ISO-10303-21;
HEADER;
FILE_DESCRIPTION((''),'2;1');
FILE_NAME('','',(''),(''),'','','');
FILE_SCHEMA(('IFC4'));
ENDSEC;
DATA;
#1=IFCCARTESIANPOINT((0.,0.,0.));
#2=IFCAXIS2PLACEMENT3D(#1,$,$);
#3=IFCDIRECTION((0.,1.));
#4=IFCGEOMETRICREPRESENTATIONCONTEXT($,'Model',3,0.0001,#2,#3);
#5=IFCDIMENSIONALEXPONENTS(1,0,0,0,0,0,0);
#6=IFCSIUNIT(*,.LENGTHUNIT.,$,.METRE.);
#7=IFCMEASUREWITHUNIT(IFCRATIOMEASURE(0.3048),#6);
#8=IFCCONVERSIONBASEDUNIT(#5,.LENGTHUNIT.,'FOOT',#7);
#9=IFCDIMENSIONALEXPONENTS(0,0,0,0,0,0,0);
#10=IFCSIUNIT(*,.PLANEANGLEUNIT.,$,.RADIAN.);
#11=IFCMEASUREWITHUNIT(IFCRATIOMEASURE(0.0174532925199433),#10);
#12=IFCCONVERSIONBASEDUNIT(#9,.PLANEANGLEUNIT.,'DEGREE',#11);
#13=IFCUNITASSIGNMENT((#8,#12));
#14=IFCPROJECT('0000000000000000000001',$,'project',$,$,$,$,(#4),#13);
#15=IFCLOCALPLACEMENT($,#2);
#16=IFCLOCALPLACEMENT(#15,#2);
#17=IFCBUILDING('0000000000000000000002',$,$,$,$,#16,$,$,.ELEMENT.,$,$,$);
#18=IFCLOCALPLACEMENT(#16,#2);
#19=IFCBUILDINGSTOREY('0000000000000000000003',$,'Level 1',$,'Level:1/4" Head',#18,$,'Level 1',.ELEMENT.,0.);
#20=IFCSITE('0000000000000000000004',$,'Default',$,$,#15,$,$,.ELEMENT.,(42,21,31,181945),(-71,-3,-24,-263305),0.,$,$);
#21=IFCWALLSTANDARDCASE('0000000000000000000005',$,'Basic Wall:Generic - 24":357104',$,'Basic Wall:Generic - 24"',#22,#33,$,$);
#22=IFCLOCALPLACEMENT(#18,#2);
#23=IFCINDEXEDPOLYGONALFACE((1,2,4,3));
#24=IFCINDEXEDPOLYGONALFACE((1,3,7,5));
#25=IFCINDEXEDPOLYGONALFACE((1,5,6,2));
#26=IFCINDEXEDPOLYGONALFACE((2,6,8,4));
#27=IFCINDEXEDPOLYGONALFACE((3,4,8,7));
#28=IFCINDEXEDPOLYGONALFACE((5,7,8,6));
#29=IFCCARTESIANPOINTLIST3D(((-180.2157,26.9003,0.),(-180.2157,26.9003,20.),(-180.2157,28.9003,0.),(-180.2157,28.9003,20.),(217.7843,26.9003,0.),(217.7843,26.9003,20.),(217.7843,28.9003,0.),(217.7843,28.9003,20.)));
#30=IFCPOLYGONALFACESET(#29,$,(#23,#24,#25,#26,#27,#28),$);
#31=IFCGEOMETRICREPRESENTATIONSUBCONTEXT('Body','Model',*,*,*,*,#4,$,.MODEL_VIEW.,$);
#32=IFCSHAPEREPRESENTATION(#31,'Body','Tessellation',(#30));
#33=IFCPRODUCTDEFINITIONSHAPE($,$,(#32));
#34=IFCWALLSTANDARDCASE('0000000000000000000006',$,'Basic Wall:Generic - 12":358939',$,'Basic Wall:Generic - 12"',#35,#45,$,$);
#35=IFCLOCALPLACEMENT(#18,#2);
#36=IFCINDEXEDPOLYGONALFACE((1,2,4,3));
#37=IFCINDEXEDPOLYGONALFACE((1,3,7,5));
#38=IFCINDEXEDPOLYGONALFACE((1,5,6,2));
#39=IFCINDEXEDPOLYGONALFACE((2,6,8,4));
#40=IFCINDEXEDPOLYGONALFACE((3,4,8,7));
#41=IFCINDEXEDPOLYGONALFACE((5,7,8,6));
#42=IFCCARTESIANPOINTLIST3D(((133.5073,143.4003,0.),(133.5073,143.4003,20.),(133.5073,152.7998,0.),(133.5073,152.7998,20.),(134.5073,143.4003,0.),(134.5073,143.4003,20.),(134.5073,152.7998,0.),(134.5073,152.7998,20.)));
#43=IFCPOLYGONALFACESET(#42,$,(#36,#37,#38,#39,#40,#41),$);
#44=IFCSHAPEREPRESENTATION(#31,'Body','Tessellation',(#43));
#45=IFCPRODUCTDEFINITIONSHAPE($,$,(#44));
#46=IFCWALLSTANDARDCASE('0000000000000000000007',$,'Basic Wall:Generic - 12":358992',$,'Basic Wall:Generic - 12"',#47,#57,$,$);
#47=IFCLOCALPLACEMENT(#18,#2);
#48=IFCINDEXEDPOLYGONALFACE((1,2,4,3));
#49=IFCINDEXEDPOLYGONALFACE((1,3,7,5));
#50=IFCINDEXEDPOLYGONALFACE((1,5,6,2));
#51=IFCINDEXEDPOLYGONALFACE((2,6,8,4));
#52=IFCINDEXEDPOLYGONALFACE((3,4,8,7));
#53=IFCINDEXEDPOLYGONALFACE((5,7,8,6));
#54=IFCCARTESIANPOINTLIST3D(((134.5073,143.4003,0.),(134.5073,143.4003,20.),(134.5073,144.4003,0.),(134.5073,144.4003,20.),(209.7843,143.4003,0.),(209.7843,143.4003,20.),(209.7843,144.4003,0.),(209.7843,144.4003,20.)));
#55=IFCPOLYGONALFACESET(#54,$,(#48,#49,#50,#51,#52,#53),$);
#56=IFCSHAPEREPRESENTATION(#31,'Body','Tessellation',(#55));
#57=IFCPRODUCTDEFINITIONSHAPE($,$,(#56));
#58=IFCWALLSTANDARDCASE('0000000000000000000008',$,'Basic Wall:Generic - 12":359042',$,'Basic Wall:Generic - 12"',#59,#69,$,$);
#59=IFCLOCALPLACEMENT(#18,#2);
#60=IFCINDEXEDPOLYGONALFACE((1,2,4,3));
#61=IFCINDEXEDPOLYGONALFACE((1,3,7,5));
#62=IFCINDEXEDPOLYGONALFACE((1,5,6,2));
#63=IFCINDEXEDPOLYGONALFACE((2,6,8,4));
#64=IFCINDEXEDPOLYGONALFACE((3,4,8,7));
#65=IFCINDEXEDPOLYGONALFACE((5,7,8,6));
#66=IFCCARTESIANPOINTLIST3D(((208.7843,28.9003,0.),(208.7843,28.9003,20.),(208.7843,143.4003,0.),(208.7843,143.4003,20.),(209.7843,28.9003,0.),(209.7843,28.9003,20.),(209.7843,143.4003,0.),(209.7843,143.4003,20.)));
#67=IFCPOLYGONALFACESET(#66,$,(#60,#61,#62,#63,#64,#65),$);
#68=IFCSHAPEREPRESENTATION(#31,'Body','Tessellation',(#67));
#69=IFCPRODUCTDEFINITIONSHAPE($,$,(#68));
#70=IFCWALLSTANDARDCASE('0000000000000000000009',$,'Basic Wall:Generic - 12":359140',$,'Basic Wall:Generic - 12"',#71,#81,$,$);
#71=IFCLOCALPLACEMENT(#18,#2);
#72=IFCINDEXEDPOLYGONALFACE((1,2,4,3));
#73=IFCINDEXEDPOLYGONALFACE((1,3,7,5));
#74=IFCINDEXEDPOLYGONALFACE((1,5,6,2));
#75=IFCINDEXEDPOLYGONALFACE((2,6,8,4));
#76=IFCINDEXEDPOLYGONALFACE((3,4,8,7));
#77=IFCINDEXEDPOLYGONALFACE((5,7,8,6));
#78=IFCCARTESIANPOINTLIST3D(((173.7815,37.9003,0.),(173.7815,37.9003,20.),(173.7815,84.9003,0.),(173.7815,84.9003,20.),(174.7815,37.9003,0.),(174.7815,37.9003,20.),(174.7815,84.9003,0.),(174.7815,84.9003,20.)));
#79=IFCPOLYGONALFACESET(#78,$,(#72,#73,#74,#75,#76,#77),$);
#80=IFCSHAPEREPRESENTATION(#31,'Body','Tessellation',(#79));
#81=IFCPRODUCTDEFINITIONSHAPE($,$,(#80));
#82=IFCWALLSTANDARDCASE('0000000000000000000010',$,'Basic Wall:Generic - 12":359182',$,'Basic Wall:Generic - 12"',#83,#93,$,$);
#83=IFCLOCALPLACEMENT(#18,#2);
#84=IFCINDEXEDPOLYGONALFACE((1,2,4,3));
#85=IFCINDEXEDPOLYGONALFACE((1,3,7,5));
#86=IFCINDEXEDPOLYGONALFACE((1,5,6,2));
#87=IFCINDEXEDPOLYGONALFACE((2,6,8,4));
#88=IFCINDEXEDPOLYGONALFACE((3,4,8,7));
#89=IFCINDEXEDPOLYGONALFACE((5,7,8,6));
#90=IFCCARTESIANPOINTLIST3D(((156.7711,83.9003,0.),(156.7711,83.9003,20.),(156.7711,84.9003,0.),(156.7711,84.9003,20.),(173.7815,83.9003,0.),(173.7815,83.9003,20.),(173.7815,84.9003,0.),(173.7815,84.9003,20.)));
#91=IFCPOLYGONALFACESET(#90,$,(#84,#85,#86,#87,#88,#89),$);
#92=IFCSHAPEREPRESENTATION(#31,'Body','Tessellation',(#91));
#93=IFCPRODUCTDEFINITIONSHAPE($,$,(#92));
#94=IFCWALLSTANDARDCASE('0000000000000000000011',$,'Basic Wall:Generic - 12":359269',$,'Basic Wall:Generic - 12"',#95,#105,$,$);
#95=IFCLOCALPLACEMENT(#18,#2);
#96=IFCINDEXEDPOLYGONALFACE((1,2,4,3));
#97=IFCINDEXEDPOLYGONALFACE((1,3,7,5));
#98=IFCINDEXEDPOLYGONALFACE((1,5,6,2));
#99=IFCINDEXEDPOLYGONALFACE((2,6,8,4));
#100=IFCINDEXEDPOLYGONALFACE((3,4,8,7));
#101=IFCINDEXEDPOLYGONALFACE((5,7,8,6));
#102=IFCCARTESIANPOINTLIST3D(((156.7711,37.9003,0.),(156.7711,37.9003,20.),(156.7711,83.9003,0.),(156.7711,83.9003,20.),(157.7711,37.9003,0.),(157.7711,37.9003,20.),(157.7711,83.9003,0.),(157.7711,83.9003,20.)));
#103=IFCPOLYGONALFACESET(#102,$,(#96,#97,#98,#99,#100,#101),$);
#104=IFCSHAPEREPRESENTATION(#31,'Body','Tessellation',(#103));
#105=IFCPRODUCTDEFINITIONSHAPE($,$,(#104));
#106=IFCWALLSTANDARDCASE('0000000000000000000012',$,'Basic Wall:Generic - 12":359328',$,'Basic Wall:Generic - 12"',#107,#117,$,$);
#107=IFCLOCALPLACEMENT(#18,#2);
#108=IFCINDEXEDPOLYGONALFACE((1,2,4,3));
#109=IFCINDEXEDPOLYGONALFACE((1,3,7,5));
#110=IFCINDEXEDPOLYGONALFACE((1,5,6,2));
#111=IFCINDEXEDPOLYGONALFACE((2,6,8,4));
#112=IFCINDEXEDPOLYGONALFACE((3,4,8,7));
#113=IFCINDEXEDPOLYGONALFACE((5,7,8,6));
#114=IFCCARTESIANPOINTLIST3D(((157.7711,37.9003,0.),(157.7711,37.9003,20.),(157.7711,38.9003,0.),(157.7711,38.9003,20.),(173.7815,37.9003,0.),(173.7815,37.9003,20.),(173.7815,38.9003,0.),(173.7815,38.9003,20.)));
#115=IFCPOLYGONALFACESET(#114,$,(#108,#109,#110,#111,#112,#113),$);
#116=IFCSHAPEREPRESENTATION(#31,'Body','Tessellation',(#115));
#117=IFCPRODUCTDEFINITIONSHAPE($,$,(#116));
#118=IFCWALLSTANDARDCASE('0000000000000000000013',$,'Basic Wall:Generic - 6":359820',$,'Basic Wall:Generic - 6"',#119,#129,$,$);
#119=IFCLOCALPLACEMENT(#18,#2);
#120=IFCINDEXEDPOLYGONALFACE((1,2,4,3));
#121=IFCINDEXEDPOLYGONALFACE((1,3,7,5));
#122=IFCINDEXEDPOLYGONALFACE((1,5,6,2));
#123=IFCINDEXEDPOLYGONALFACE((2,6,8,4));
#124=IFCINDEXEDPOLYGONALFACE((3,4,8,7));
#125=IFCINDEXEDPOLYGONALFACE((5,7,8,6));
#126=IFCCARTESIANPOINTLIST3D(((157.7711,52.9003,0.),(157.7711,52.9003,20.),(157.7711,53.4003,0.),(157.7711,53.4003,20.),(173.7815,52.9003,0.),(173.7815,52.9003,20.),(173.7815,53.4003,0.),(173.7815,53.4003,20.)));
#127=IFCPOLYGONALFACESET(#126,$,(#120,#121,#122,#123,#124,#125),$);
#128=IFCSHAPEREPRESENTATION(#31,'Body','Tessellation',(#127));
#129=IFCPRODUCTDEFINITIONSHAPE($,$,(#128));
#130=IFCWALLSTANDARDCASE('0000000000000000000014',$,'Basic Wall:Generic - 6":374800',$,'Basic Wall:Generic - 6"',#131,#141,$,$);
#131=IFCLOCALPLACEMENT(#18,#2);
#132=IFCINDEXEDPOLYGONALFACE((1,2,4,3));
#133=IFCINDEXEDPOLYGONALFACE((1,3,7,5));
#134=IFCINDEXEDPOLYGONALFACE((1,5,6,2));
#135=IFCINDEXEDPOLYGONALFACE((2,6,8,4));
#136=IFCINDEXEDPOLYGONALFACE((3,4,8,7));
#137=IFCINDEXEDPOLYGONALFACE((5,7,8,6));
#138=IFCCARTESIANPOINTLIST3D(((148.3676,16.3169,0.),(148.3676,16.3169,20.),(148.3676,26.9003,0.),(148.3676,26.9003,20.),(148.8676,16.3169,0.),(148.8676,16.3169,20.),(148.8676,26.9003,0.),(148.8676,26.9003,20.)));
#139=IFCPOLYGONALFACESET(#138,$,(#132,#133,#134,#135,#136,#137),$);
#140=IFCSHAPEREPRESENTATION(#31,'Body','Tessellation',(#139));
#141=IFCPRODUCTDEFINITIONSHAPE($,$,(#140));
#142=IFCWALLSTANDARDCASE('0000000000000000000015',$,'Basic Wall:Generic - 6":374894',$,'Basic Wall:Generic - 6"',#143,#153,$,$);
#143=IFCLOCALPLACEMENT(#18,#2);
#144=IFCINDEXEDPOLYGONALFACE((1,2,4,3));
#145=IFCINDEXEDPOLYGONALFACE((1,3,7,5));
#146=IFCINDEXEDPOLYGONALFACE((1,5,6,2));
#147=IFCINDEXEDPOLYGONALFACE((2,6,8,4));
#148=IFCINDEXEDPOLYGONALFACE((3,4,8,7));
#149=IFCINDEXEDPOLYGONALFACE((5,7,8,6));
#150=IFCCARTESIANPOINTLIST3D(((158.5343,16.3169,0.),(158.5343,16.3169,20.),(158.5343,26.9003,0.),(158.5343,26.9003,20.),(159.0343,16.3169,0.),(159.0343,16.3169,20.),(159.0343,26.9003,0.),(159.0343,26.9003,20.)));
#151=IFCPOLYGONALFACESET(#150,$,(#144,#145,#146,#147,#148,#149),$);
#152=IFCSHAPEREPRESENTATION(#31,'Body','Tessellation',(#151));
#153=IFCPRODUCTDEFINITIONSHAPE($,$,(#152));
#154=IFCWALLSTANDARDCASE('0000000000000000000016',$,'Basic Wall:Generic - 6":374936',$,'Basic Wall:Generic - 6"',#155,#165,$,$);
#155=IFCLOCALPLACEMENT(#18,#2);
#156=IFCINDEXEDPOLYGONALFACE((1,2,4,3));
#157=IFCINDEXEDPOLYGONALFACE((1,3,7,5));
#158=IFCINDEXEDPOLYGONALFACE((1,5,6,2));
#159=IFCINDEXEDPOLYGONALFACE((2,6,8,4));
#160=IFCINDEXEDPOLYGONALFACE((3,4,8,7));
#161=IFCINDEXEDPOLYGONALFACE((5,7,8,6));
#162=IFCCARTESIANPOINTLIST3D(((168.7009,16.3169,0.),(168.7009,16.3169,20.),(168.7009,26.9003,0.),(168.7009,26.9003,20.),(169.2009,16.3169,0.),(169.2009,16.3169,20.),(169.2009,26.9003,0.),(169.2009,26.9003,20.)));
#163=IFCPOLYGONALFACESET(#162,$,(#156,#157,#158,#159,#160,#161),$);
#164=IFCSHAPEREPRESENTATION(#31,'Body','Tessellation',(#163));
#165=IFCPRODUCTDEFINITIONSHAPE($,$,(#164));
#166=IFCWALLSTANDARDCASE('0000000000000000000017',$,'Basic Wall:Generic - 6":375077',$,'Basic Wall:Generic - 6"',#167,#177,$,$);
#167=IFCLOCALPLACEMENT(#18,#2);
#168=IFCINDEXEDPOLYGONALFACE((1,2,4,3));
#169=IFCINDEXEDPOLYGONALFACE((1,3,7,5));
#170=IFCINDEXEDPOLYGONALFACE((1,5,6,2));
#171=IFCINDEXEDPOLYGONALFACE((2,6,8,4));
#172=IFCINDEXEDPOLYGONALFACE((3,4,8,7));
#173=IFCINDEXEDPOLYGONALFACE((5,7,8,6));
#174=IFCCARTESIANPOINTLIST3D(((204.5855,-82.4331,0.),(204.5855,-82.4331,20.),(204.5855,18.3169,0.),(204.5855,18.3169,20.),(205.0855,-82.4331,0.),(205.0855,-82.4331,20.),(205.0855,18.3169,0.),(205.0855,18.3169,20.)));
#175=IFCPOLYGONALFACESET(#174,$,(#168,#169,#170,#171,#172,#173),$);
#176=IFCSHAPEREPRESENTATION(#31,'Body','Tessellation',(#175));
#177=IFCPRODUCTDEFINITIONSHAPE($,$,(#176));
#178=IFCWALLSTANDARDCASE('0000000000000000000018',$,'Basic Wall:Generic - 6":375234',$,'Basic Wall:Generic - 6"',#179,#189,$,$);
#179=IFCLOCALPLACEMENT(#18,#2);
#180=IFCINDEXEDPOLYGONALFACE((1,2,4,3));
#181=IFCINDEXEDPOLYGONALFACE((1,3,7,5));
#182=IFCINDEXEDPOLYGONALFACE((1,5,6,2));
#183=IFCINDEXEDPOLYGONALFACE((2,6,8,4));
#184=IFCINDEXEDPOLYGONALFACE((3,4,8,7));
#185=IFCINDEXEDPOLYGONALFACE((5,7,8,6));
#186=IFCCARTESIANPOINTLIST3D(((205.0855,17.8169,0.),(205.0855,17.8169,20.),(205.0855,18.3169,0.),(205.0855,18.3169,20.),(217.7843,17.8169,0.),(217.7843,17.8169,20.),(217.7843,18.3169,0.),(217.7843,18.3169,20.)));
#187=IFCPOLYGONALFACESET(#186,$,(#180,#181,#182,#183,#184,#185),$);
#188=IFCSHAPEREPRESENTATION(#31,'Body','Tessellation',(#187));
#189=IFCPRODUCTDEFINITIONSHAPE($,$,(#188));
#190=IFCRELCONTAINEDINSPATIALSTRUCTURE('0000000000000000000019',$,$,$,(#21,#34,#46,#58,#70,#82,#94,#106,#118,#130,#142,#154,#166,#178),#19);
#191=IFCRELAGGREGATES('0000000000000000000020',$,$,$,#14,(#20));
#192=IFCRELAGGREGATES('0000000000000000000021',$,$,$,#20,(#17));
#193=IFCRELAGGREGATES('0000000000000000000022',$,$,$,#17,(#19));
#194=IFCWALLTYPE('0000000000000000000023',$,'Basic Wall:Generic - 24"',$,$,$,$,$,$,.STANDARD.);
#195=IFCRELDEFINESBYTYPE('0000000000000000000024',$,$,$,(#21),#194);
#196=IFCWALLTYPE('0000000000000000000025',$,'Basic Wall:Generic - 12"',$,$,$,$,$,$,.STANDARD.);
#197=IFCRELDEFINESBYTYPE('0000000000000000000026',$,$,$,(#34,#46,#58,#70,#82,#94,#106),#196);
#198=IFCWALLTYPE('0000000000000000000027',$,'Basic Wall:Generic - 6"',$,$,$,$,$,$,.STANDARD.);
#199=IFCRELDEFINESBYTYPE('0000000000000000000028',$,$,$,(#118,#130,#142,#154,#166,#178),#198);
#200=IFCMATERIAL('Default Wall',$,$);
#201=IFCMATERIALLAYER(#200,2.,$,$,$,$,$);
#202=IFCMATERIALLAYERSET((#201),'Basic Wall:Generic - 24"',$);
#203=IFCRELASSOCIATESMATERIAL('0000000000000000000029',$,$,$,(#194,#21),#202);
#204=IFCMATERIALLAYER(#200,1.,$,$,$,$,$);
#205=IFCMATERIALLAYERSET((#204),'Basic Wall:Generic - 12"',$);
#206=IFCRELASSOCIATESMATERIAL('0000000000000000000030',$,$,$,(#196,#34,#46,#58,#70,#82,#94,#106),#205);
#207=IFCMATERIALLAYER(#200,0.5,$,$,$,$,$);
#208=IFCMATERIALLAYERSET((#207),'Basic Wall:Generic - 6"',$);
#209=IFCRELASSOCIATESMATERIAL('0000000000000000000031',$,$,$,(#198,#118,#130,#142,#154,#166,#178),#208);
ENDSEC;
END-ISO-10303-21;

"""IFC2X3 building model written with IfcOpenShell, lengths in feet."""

from ifc_helpers import new_model, entity, si_unit, converted_unit, direction, frame, frame_2d, origin, place, context, subcontext, project, spatial, rectangle, extrude, material, layer, layer_set, layer_usage, type_object, element, save


model = new_model("IFC2X3")

# Units and contexts
model_context = context("Model", 3, precision=0.0001, world=origin(), true_north=direction((0.0, 1.0)))
body_context = subcontext(model_context, "Body", "Model", "MODEL_VIEW")
ifc_project = project(units=[converted_unit("LENGTHUNIT", "FOOT", entity("IfcRatioMeasure", 0.3048), si_unit("LENGTHUNIT", "METRE"), dimensions=[1, 0, 0, 0, 0, 0, 0]), converted_unit("PLANEANGLEUNIT", "DEGREE", entity("IfcRatioMeasure", 0.0174532925199433), si_unit("PLANEANGLEUNIT", "RADIAN"), dimensions=[0, 0, 0, 0, 0, 0, 0])], contexts=[model_context])

# Site, building, storey
site_placement = place(None, origin())
site = spatial("IfcSite", under=ifc_project, at=site_placement, Name="Default", CompositionType="ELEMENT", RefLatitude=(42, 21, 31, 181945), RefLongitude=(-71, -3, -24, -263305), RefElevation=0.0)
building_placement = place(site_placement, origin())
building = spatial("IfcBuilding", under=site, at=building_placement, CompositionType="ELEMENT")
storey_placement = place(building_placement, origin())
storey = spatial("IfcBuildingStorey", under=building, at=storey_placement, Name="Level 1", ObjectType="Level:1/4\" Head", LongName="Level 1", CompositionType="ELEMENT", Elevation=0.0)

# Walls
ifc_material = material(Name="Default Wall")
ifc_layer_1 = layer(ifc_material, 2.0)
ifc_layer_set_1 = layer_set([ifc_layer_1], Name="Basic Wall:Generic - 24\"")
ifc_layer_usage_1 = layer_usage(ifc_layer_set_1, "AXIS2", "NEGATIVE", 1.0)
wall_type_1 = type_object("IfcWallType", Name="Basic Wall:Generic - 24\"", PredefinedType="STANDARD", material=ifc_layer_set_1)
wall_1_placement = place(storey_placement, frame((217.7843, 27.9003, 0.0), z_axis=(0.0, 0.0, 1.0), x_axis=(-1.0, 0.0, 0.0)))
element("IfcWallStandardCase", 1, at=wall_1_placement, inside=storey, type_object=wall_type_1, material=ifc_layer_usage_1, Name="Basic Wall:Generic - 24\":357104", ObjectType="Basic Wall:Generic - 24\"", context=body_context, shape_type="SweptSolid", body=[
    extrude(rectangle(XDim=398.0, YDim=2.0, at=frame_2d((199.0, 0.0), x_axis=(-1.0, 0.0))), origin(), (0.0, 0.0, 1.0), 20.0),
])
ifc_layer_2 = layer(ifc_material, 1.0)
ifc_layer_set_2 = layer_set([ifc_layer_2], Name="Basic Wall:Generic - 12\"")
ifc_layer_usage_2 = layer_usage(ifc_layer_set_2, "AXIS2", "NEGATIVE", 0.5)
wall_type_2 = type_object("IfcWallType", Name="Basic Wall:Generic - 12\"", PredefinedType="STANDARD", material=ifc_layer_set_2)
wall_2_placement = place(storey_placement, frame((134.0073, 152.7998, 0.0), z_axis=(0.0, 0.0, 1.0), x_axis=(0.0, -1.0, 0.0)))
element("IfcWallStandardCase", 2, at=wall_2_placement, inside=storey, type_object=wall_type_2, material=ifc_layer_usage_2, Name="Basic Wall:Generic - 12\":358939", ObjectType="Basic Wall:Generic - 12\"", context=body_context, shape_type="SweptSolid", body=[
    extrude(rectangle(XDim=9.3995, YDim=1.0, at=frame_2d((4.6998, 0.0), x_axis=(-1.0, 0.0))), origin(), (0.0, 0.0, 1.0), 20.0),
])
ifc_layer_usage_3 = layer_usage(ifc_layer_set_2, "AXIS2", "NEGATIVE", 0.5)
wall_3_placement = place(storey_placement, frame((134.5073, 143.9003, 0.0)))
element("IfcWallStandardCase", 3, at=wall_3_placement, inside=storey, type_object=wall_type_2, material=ifc_layer_usage_3, Name="Basic Wall:Generic - 12\":358992", ObjectType="Basic Wall:Generic - 12\"", context=body_context, shape_type="SweptSolid", body=[
    extrude(rectangle(XDim=75.2769, YDim=1.0, at=frame_2d((37.6385, 0.0), x_axis=(-1.0, 0.0))), origin(), (0.0, 0.0, 1.0), 20.0),
])
ifc_layer_usage_4 = layer_usage(ifc_layer_set_2, "AXIS2", "NEGATIVE", 0.5)
wall_4_placement = place(storey_placement, frame((209.2843, 143.4003, 0.0), z_axis=(0.0, 0.0, 1.0), x_axis=(0.0, -1.0, 0.0)))
element("IfcWallStandardCase", 4, at=wall_4_placement, inside=storey, type_object=wall_type_2, material=ifc_layer_usage_4, Name="Basic Wall:Generic - 12\":359042", ObjectType="Basic Wall:Generic - 12\"", context=body_context, shape_type="SweptSolid", body=[
    extrude(rectangle(XDim=114.5, YDim=1.0, at=frame_2d((57.25, 0.0), x_axis=(-1.0, 0.0))), origin(), (0.0, 0.0, 1.0), 20.0),
])
ifc_layer_usage_5 = layer_usage(ifc_layer_set_2, "AXIS2", "NEGATIVE", 0.5)
wall_5_placement = place(storey_placement, frame((174.2815, 37.9003, 0.0), z_axis=(0.0, 0.0, 1.0), x_axis=(0.0, 1.0, 0.0)))
element("IfcWallStandardCase", 5, at=wall_5_placement, inside=storey, type_object=wall_type_2, material=ifc_layer_usage_5, Name="Basic Wall:Generic - 12\":359140", ObjectType="Basic Wall:Generic - 12\"", context=body_context, shape_type="SweptSolid", body=[
    extrude(rectangle(XDim=47.0, YDim=1.0, at=frame_2d((23.5, 0.0), x_axis=(-1.0, 0.0))), origin(), (0.0, 0.0, 1.0), 20.0),
])
ifc_layer_usage_6 = layer_usage(ifc_layer_set_2, "AXIS2", "NEGATIVE", 0.5)
wall_6_placement = place(storey_placement, frame((173.7815, 84.4003, 0.0), z_axis=(0.0, 0.0, 1.0), x_axis=(-1.0, 0.0, 0.0)))
element("IfcWallStandardCase", 6, at=wall_6_placement, inside=storey, type_object=wall_type_2, material=ifc_layer_usage_6, Name="Basic Wall:Generic - 12\":359182", ObjectType="Basic Wall:Generic - 12\"", context=body_context, shape_type="SweptSolid", body=[
    extrude(rectangle(XDim=17.0104, YDim=1.0, at=frame_2d((8.5052, 0.0), x_axis=(-1.0, 0.0))), origin(), (0.0, 0.0, 1.0), 20.0),
])
ifc_layer_usage_7 = layer_usage(ifc_layer_set_2, "AXIS2", "NEGATIVE", 0.5)
wall_7_placement = place(storey_placement, frame((157.2711, 83.9003, 0.0), z_axis=(0.0, 0.0, 1.0), x_axis=(0.0, -1.0, 0.0)))
element("IfcWallStandardCase", 7, at=wall_7_placement, inside=storey, type_object=wall_type_2, material=ifc_layer_usage_7, Name="Basic Wall:Generic - 12\":359269", ObjectType="Basic Wall:Generic - 12\"", context=body_context, shape_type="SweptSolid", body=[
    extrude(rectangle(XDim=46.0, YDim=1.0, at=frame_2d((23.0, 0.0), x_axis=(-1.0, 0.0))), origin(), (0.0, 0.0, 1.0), 20.0),
])
ifc_layer_usage_8 = layer_usage(ifc_layer_set_2, "AXIS2", "NEGATIVE", 0.5)
wall_8_placement = place(storey_placement, frame((157.7711, 38.4003, 0.0)))
element("IfcWallStandardCase", 8, at=wall_8_placement, inside=storey, type_object=wall_type_2, material=ifc_layer_usage_8, Name="Basic Wall:Generic - 12\":359328", ObjectType="Basic Wall:Generic - 12\"", context=body_context, shape_type="SweptSolid", body=[
    extrude(rectangle(XDim=16.0104, YDim=1.0, at=frame_2d((8.0052, 0.0), x_axis=(-1.0, 0.0))), origin(), (0.0, 0.0, 1.0), 20.0),
])
ifc_layer_3 = layer(ifc_material, 0.5)
ifc_layer_set_3 = layer_set([ifc_layer_3], Name="Basic Wall:Generic - 6\"")
ifc_layer_usage_9 = layer_usage(ifc_layer_set_3, "AXIS2", "NEGATIVE", 0.25)
wall_type_3 = type_object("IfcWallType", Name="Basic Wall:Generic - 6\"", PredefinedType="STANDARD", material=ifc_layer_set_3)
wall_9_placement = place(storey_placement, frame((157.7711, 53.1503, 0.0)))
element("IfcWallStandardCase", 9, at=wall_9_placement, inside=storey, type_object=wall_type_3, material=ifc_layer_usage_9, Name="Basic Wall:Generic - 6\":359820", ObjectType="Basic Wall:Generic - 6\"", context=body_context, shape_type="SweptSolid", body=[
    extrude(rectangle(XDim=16.0104, YDim=0.5, at=frame_2d((8.0052, 0.0), x_axis=(-1.0, 0.0))), origin(), (0.0, 0.0, 1.0), 20.0),
])
ifc_layer_usage_10 = layer_usage(ifc_layer_set_3, "AXIS2", "NEGATIVE", 0.25)
wall_10_placement = place(storey_placement, frame((148.6176, 26.9003, 0.0), z_axis=(0.0, 0.0, 1.0), x_axis=(0.0, -1.0, 0.0)))
element("IfcWallStandardCase", 10, at=wall_10_placement, inside=storey, type_object=wall_type_3, material=ifc_layer_usage_10, Name="Basic Wall:Generic - 6\":374800", ObjectType="Basic Wall:Generic - 6\"", context=body_context, shape_type="SweptSolid", body=[
    extrude(rectangle(XDim=10.5833, YDim=0.5, at=frame_2d((5.2917, 0.0), x_axis=(-1.0, 0.0))), origin(), (0.0, 0.0, 1.0), 20.0),
])
ifc_layer_usage_11 = layer_usage(ifc_layer_set_3, "AXIS2", "NEGATIVE", 0.25)
wall_11_placement = place(storey_placement, frame((158.7843, 26.9003, 0.0), z_axis=(0.0, 0.0, 1.0), x_axis=(0.0, -1.0, 0.0)))
element("IfcWallStandardCase", 11, at=wall_11_placement, inside=storey, type_object=wall_type_3, material=ifc_layer_usage_11, Name="Basic Wall:Generic - 6\":374894", ObjectType="Basic Wall:Generic - 6\"", context=body_context, shape_type="SweptSolid", body=[
    extrude(rectangle(XDim=10.5833, YDim=0.5, at=frame_2d((5.2917, 0.0), x_axis=(-1.0, 0.0))), origin(), (0.0, 0.0, 1.0), 20.0),
])
ifc_layer_usage_12 = layer_usage(ifc_layer_set_3, "AXIS2", "NEGATIVE", 0.25)
wall_12_placement = place(storey_placement, frame((168.9509, 26.9003, 0.0), z_axis=(0.0, 0.0, 1.0), x_axis=(0.0, -1.0, 0.0)))
element("IfcWallStandardCase", 12, at=wall_12_placement, inside=storey, type_object=wall_type_3, material=ifc_layer_usage_12, Name="Basic Wall:Generic - 6\":374936", ObjectType="Basic Wall:Generic - 6\"", context=body_context, shape_type="SweptSolid", body=[
    extrude(rectangle(XDim=10.5833, YDim=0.5, at=frame_2d((5.2917, 0.0), x_axis=(-1.0, 0.0))), origin(), (0.0, 0.0, 1.0), 20.0),
])
ifc_layer_usage_13 = layer_usage(ifc_layer_set_3, "AXIS2", "NEGATIVE", 0.25)
wall_13_placement = place(storey_placement, frame((204.8355, 18.3169, 0.0), z_axis=(0.0, 0.0, 1.0), x_axis=(0.0, -1.0, 0.0)))
element("IfcWallStandardCase", 13, at=wall_13_placement, inside=storey, type_object=wall_type_3, material=ifc_layer_usage_13, Name="Basic Wall:Generic - 6\":375077", ObjectType="Basic Wall:Generic - 6\"", context=body_context, shape_type="SweptSolid", body=[
    extrude(rectangle(XDim=100.75, YDim=0.5, at=frame_2d((50.375, 0.0), x_axis=(-1.0, 0.0))), origin(), (0.0, 0.0, 1.0), 20.0),
])
ifc_layer_usage_14 = layer_usage(ifc_layer_set_3, "AXIS2", "NEGATIVE", 0.25)
wall_14_placement = place(storey_placement, frame((205.0855, 18.0669, 0.0)))
element("IfcWallStandardCase", 14, at=wall_14_placement, inside=storey, type_object=wall_type_3, material=ifc_layer_usage_14, Name="Basic Wall:Generic - 6\":375234", ObjectType="Basic Wall:Generic - 6\"", context=body_context, shape_type="SweptSolid", body=[
    extrude(rectangle(XDim=12.6987, YDim=0.5, at=frame_2d((6.3494, 0.0), x_axis=(-1.0, 0.0))), origin(), (0.0, 0.0, 1.0), 20.0),
])

save(model, "model.ifc")
